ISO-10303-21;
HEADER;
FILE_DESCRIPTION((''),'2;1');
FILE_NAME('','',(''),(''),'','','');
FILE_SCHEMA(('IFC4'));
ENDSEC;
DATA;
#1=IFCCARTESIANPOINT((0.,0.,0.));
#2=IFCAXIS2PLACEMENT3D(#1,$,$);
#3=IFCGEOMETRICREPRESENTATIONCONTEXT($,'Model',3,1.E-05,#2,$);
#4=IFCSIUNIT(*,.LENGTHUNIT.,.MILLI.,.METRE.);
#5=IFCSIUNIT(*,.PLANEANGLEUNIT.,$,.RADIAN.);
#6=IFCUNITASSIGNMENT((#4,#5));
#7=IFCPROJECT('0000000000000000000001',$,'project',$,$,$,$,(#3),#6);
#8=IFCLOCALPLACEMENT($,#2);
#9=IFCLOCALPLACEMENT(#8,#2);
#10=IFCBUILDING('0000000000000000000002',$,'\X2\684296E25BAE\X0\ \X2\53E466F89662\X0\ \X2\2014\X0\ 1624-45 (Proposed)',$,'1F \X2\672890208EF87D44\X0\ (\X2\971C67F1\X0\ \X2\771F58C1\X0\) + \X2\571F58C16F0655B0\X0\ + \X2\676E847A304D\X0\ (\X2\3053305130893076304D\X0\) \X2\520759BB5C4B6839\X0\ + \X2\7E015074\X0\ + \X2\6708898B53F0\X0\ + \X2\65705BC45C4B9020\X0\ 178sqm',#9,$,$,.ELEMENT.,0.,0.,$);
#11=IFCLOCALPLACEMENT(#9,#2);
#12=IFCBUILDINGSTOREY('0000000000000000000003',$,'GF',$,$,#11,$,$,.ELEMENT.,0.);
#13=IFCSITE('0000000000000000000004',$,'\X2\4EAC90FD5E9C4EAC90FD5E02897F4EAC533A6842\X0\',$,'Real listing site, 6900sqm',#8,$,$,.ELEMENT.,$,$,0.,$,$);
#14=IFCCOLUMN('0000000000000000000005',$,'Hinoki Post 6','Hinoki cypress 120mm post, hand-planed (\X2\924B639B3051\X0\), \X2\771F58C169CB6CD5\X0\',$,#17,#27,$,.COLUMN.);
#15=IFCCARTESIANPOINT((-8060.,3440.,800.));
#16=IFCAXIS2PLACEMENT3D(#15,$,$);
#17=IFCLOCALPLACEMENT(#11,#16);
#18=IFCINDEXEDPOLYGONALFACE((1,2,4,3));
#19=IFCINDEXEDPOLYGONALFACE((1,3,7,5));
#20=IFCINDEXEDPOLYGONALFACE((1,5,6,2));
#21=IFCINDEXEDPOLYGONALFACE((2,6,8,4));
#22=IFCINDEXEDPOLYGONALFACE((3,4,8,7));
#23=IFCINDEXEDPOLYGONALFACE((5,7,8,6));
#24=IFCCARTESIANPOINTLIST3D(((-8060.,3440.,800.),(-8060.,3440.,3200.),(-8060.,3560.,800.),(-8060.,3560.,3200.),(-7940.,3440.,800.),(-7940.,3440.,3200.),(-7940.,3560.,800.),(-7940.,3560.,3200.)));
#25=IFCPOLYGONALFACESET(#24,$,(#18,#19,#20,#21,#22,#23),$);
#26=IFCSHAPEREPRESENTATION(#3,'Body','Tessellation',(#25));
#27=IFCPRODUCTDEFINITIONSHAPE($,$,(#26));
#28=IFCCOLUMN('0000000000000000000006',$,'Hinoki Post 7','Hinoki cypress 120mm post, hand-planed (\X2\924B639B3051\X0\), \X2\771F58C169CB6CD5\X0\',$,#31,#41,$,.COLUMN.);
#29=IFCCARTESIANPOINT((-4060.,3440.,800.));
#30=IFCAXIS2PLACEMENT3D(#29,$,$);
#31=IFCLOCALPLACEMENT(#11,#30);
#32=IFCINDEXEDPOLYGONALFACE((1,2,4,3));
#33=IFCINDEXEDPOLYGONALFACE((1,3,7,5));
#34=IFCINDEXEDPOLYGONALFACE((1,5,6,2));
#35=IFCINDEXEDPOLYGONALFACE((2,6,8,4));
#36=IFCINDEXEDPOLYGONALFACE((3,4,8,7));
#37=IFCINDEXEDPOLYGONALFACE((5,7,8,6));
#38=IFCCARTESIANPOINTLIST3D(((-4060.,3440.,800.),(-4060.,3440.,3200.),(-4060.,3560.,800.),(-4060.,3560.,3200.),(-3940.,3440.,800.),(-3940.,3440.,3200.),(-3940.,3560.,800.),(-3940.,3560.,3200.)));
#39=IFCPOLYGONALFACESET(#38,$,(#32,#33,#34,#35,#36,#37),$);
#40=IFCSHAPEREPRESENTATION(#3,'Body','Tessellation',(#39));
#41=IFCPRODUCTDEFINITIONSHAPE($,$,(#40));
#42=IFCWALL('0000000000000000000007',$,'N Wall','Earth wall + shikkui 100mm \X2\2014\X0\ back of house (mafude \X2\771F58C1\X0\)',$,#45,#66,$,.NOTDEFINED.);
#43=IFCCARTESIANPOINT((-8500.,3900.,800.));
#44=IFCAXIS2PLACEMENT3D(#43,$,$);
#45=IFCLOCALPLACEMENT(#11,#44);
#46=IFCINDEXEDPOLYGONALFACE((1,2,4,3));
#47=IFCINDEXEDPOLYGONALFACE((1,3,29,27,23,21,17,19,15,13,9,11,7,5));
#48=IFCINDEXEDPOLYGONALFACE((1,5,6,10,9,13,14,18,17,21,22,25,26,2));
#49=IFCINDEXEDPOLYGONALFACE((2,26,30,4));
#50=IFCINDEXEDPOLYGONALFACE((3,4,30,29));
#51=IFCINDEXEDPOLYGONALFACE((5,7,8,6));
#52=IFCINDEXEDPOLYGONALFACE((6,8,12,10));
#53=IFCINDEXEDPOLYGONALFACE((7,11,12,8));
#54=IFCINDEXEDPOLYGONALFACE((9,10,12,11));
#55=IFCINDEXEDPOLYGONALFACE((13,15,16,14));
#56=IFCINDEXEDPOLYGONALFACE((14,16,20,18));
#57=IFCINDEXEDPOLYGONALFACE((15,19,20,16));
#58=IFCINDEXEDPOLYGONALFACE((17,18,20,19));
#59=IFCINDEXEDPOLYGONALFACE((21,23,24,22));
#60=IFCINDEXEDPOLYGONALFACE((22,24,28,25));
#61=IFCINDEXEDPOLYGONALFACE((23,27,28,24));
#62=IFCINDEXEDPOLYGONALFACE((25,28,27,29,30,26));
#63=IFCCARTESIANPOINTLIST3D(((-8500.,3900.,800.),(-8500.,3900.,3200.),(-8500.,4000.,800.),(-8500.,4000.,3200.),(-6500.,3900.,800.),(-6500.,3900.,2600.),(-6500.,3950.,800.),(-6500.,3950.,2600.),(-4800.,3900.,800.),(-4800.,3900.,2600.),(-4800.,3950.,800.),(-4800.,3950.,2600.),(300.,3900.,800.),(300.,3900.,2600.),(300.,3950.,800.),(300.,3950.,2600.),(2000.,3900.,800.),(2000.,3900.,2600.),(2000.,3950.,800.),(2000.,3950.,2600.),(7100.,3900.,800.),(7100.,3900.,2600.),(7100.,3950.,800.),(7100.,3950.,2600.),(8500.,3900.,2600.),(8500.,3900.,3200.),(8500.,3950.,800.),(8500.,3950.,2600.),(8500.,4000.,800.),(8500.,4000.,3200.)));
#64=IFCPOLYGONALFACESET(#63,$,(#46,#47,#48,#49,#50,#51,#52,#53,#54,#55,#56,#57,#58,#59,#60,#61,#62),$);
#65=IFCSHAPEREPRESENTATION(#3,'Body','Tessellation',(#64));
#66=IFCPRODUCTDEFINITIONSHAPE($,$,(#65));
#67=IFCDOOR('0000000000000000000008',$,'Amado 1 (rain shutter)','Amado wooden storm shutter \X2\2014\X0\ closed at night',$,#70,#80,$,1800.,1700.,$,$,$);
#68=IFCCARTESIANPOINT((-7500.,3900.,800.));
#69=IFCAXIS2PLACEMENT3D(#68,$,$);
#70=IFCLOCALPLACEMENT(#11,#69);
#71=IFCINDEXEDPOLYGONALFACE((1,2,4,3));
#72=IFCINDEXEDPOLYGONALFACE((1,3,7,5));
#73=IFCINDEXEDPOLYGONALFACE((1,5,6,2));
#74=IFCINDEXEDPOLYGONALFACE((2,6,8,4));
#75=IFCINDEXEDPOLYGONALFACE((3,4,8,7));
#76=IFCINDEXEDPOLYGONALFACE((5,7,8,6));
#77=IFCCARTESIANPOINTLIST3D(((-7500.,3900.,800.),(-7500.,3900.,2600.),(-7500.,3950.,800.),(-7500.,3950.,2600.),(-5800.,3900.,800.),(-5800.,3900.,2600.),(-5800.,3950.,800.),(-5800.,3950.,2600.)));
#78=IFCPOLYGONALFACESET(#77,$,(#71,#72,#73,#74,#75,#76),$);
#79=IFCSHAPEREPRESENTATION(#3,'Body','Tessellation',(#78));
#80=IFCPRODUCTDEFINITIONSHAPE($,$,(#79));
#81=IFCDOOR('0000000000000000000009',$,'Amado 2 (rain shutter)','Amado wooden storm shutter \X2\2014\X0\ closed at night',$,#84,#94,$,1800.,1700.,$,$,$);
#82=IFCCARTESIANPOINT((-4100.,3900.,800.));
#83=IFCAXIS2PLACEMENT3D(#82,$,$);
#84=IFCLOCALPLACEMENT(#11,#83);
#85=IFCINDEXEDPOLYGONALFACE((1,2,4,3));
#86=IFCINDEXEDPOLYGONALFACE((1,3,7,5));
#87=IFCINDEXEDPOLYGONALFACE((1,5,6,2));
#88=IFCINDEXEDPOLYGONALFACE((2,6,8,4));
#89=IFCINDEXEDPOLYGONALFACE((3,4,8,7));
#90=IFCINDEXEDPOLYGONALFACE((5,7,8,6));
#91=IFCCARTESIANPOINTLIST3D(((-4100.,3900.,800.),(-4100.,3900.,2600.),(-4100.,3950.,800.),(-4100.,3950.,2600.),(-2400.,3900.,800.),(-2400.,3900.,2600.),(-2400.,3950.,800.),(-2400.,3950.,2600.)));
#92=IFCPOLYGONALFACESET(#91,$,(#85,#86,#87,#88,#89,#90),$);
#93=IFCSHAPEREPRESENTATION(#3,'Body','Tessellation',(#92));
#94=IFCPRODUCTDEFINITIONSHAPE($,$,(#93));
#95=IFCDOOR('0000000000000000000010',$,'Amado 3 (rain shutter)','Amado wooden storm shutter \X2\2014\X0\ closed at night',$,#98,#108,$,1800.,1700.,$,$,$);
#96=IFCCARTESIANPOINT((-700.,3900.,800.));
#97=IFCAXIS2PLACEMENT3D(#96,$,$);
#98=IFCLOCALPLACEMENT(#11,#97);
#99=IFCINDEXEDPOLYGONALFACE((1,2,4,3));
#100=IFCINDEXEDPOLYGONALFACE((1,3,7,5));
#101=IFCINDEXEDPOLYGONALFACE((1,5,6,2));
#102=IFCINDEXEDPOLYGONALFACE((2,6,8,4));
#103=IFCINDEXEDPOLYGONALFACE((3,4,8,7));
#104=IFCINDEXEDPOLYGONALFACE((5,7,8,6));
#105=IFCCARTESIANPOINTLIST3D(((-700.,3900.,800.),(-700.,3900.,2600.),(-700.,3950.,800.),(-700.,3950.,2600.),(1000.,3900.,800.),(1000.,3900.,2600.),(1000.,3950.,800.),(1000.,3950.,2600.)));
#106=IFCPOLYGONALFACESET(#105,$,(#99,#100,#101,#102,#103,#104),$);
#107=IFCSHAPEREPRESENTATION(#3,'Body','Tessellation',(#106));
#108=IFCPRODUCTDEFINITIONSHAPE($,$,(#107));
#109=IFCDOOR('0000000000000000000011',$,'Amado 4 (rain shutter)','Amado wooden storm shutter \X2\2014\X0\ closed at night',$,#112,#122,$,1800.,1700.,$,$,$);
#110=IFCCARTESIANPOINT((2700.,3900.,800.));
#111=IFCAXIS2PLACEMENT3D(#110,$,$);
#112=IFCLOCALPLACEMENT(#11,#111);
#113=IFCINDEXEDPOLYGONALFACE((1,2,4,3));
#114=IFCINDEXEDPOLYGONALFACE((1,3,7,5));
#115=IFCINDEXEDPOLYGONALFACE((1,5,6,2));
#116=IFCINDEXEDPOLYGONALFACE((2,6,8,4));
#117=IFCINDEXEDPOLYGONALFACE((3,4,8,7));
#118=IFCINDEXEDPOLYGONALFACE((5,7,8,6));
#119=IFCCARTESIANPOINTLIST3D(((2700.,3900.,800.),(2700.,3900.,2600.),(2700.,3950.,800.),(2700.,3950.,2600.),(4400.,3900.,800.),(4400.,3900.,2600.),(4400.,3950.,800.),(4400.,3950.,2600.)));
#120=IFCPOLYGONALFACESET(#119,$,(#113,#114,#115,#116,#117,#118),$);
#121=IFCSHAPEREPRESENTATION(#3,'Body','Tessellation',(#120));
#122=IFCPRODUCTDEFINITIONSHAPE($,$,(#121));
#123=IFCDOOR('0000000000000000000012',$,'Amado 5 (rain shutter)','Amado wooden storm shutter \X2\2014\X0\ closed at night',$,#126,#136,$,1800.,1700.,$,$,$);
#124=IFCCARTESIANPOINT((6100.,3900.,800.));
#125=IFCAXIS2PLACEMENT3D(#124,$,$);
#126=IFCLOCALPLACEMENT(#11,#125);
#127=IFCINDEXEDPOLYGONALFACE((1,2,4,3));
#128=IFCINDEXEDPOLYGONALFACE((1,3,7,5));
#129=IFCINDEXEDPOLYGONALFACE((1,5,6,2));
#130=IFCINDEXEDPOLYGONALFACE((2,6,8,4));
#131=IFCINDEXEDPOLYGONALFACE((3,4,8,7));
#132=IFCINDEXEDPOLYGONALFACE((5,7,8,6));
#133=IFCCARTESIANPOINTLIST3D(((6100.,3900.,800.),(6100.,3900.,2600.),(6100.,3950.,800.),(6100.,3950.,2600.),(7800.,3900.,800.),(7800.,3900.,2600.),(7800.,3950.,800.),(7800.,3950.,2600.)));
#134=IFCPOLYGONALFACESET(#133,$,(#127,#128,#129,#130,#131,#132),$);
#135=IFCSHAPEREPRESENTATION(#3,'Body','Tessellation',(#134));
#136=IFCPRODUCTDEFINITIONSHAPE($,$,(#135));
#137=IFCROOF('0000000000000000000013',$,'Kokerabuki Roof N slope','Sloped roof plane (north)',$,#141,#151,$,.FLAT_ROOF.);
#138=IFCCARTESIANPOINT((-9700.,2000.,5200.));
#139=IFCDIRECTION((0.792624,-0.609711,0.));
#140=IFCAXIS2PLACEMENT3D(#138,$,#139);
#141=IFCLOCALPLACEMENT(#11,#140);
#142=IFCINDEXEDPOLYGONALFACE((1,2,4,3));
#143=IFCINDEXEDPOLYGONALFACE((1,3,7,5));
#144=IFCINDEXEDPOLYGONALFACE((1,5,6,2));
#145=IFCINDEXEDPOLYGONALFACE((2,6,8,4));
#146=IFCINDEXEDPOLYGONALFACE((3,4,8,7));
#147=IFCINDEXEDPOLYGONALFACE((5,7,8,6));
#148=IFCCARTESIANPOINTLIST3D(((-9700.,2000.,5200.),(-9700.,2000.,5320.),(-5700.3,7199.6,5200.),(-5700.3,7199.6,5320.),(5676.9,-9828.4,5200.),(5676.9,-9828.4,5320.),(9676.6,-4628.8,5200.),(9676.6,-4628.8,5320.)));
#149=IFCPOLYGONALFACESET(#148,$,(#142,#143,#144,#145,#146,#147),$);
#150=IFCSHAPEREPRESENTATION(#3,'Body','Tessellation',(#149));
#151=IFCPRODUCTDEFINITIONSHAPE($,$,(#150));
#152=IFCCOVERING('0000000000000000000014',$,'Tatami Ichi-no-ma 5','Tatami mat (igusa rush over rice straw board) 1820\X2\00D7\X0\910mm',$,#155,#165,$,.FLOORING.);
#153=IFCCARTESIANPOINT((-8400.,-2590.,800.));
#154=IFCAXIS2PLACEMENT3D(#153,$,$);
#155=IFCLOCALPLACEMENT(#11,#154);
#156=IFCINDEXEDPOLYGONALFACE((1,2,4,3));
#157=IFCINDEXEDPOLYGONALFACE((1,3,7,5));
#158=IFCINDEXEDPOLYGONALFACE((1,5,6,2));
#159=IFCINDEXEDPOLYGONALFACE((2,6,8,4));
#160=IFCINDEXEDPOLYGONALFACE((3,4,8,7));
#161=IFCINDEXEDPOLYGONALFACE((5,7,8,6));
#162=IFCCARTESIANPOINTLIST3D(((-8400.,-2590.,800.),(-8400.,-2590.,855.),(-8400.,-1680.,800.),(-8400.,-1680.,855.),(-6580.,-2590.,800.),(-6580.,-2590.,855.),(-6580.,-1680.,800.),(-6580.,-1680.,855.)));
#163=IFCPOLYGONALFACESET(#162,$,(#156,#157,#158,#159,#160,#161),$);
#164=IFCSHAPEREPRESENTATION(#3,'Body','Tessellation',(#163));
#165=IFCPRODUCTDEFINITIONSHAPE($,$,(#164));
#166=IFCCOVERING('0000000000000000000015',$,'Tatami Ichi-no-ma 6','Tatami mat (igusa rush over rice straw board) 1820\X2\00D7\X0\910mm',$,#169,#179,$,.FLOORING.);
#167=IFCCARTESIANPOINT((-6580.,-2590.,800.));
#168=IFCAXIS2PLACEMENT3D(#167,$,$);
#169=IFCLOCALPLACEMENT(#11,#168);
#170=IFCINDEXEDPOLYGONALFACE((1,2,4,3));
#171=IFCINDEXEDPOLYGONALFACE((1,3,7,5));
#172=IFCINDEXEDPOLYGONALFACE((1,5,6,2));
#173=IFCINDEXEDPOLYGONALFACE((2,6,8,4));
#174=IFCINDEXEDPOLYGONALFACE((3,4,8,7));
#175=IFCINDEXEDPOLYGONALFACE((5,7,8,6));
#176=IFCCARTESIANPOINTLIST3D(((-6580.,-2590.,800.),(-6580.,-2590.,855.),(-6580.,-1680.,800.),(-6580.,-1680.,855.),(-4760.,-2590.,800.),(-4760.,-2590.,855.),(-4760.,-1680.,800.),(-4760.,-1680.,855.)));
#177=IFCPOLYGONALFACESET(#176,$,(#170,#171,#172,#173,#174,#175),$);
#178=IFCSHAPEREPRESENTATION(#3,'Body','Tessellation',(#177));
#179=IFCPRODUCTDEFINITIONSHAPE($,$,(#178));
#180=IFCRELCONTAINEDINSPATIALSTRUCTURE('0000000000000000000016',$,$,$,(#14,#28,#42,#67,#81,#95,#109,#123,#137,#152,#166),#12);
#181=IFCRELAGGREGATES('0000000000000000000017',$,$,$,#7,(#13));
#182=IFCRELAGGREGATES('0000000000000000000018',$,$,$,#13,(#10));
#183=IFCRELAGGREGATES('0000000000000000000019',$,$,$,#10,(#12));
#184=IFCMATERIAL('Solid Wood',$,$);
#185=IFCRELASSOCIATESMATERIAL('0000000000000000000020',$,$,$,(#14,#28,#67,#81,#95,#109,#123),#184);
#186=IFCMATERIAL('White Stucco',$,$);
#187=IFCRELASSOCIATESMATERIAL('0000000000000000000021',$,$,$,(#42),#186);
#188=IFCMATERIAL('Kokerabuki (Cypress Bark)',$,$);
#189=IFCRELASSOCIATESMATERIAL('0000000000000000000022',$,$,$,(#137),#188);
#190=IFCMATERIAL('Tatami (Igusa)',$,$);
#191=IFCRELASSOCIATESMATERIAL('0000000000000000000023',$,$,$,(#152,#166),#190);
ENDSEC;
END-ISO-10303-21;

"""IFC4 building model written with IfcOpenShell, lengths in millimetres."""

from ifc_helpers import new_model, si_unit, frame, frame_2d, origin, place, context, project, spatial, rectangle, extrude, material, element, fill, save


model = new_model("IFC4")

# Units and contexts
model_context = context("Model", 3, precision=1e-05, world=origin())
ifc_project = project(units=[si_unit("LENGTHUNIT", "METRE", prefix="MILLI"), si_unit("PLANEANGLEUNIT", "RADIAN")], contexts=[model_context])

# Site, building, storey
site_placement = place(None, origin())
site = spatial("IfcSite", under=ifc_project, at=site_placement, Name="京都府京都市西京区桂", ObjectType="Real listing site, 6900sqm", CompositionType="ELEMENT", RefElevation=0.0)
building_placement = place(site_placement, origin())
building = spatial("IfcBuilding", under=site, at=building_placement, Name="桂離宮 古書院 — 1624-45 (Proposed)", ObjectType="1F 木造軸組 (霜柱 真壁) + 土壁漆喰 + 杮葺き (こけらぶき) 切妻屋根 + 縁側 + 月見台 + 数寄屋造 178sqm", CompositionType="ELEMENT", ElevationOfRefHeight=0.0, ElevationOfTerrain=0.0)
storey_placement = place(building_placement, origin())
storey = spatial("IfcBuildingStorey", under=building, at=storey_placement, Name="GF", CompositionType="ELEMENT", Elevation=0.0)

# Columns
ifc_material_1 = material(Name="Solid Wood")
column_1_placement = place(storey_placement, frame((-8060.0, 3440.0, 800.0)))
element("IfcColumn", 1, at=column_1_placement, inside=storey, material=ifc_material_1, Name="Hinoki Post 6", Description="Hinoki cypress 120mm post, hand-planed (鉋掛け), 真壁構法", PredefinedType="COLUMN", context=model_context, shape_type="SweptSolid", body=[
    extrude(rectangle(XDim=120.0, YDim=120.0, at=frame_2d((60.0, 60.0))), frame((-8060.0, 3440.0, 800.0)), (0.0, 0.0, 1.0), 2400.0),
])
column_2_placement = place(storey_placement, frame((-4060.0, 3440.0, 800.0)))
element("IfcColumn", 2, at=column_2_placement, inside=storey, material=ifc_material_1, Name="Hinoki Post 7", Description="Hinoki cypress 120mm post, hand-planed (鉋掛け), 真壁構法", PredefinedType="COLUMN", context=model_context, shape_type="SweptSolid", body=[
    extrude(rectangle(XDim=120.0, YDim=120.0, at=frame_2d((60.0, 60.0))), frame((-4060.0, 3440.0, 800.0)), (0.0, 0.0, 1.0), 2400.0),
])

# Wall, openings, doors
ifc_material_2 = material(Name="White Stucco")
wall_placement = place(storey_placement, frame((-8500.0, 3900.0, 800.0)))
wall = element("IfcWall", 3, at=wall_placement, inside=storey, material=ifc_material_2, Name="N Wall", Description="Earth wall + shikkui 100mm — back of house (mafude 真壁)", PredefinedType="NOTDEFINED", context=model_context, shape_type="SweptSolid", body=[
    extrude(rectangle(XDim=17000.0, YDim=100.0, at=frame_2d((8500.0, 50.0))), frame((-8500.0, 3900.0, 800.0)), (0.0, 0.0, 1.0), 2400.0),
])
opening_1_placement = place(storey_placement, frame((-7500.0, 3900.0, 800.0)))
opening_1 = element("IfcOpeningElement", 4, at=opening_1_placement, cuts=wall, PredefinedType="NOTDEFINED", context=model_context, shape_type="SweptSolid", body=[
    extrude(rectangle(XDim=1700.0, YDim=50.0, at=frame_2d((850.0, 25.0))), frame((-7500.0, 3900.0, 800.0)), (0.0, 0.0, 1.0), 1800.0),
])
opening_2_placement = place(storey_placement, frame((-4100.0, 3900.0, 800.0)))
opening_2 = element("IfcOpeningElement", 5, at=opening_2_placement, cuts=wall, PredefinedType="NOTDEFINED", context=model_context, shape_type="SweptSolid", body=[
    extrude(rectangle(XDim=1700.0, YDim=50.0, at=frame_2d((850.0, 25.0))), frame((-4100.0, 3900.0, 800.0)), (0.0, 0.0, 1.0), 1800.0),
])
opening_3_placement = place(storey_placement, frame((-700.0, 3900.0, 800.0)))
opening_3 = element("IfcOpeningElement", 6, at=opening_3_placement, cuts=wall, PredefinedType="NOTDEFINED", context=model_context, shape_type="SweptSolid", body=[
    extrude(rectangle(XDim=1700.0, YDim=50.0, at=frame_2d((850.0, 25.0))), frame((-700.0, 3900.0, 800.0)), (0.0, 0.0, 1.0), 1800.0),
])
opening_4_placement = place(storey_placement, frame((2700.0, 3900.0, 800.0)))
opening_4 = element("IfcOpeningElement", 7, at=opening_4_placement, cuts=wall, PredefinedType="NOTDEFINED", context=model_context, shape_type="SweptSolid", body=[
    extrude(rectangle(XDim=1700.0, YDim=50.0, at=frame_2d((850.0, 25.0))), frame((2700.0, 3900.0, 800.0)), (0.0, 0.0, 1.0), 1800.0),
])
opening_5_placement = place(storey_placement, frame((6100.0, 3900.0, 800.0)))
opening_5 = element("IfcOpeningElement", 8, at=opening_5_placement, cuts=wall, PredefinedType="NOTDEFINED", context=model_context, shape_type="SweptSolid", body=[
    extrude(rectangle(XDim=1700.0, YDim=50.0, at=frame_2d((850.0, 25.0))), frame((6100.0, 3900.0, 800.0)), (0.0, 0.0, 1.0), 1800.0),
])
door_1_placement = place(storey_placement, frame((-7500.0, 3900.0, 800.0)))
door_1 = element("IfcDoor", 9, at=door_1_placement, inside=storey, material=ifc_material_1, Name="Amado 1 (rain shutter)", Description="Amado wooden storm shutter — closed at night", OverallHeight=1800.0, OverallWidth=1700.0, context=model_context, shape_type="SweptSolid", body=[
    extrude(rectangle(XDim=1700.0, YDim=50.0, at=frame_2d((850.0, 25.0))), frame((-7500.0, 3900.0, 800.0)), (0.0, 0.0, 1.0), 1800.0),
])
fill(opening_1, door_1)
door_2_placement = place(storey_placement, frame((-4100.0, 3900.0, 800.0)))
door_2 = element("IfcDoor", 10, at=door_2_placement, inside=storey, material=ifc_material_1, Name="Amado 2 (rain shutter)", Description="Amado wooden storm shutter — closed at night", OverallHeight=1800.0, OverallWidth=1700.0, context=model_context, shape_type="SweptSolid", body=[
    extrude(rectangle(XDim=1700.0, YDim=50.0, at=frame_2d((850.0, 25.0))), frame((-4100.0, 3900.0, 800.0)), (0.0, 0.0, 1.0), 1800.0),
])
fill(opening_2, door_2)
door_3_placement = place(storey_placement, frame((-700.0, 3900.0, 800.0)))
door_3 = element("IfcDoor", 11, at=door_3_placement, inside=storey, material=ifc_material_1, Name="Amado 3 (rain shutter)", Description="Amado wooden storm shutter — closed at night", OverallHeight=1800.0, OverallWidth=1700.0, context=model_context, shape_type="SweptSolid", body=[
    extrude(rectangle(XDim=1700.0, YDim=50.0, at=frame_2d((850.0, 25.0))), frame((-700.0, 3900.0, 800.0)), (0.0, 0.0, 1.0), 1800.0),
])
fill(opening_3, door_3)
door_4_placement = place(storey_placement, frame((2700.0, 3900.0, 800.0)))
door_4 = element("IfcDoor", 12, at=door_4_placement, inside=storey, material=ifc_material_1, Name="Amado 4 (rain shutter)", Description="Amado wooden storm shutter — closed at night", OverallHeight=1800.0, OverallWidth=1700.0, context=model_context, shape_type="SweptSolid", body=[
    extrude(rectangle(XDim=1700.0, YDim=50.0, at=frame_2d((850.0, 25.0))), frame((2700.0, 3900.0, 800.0)), (0.0, 0.0, 1.0), 1800.0),
])
fill(opening_4, door_4)
door_5_placement = place(storey_placement, frame((6100.0, 3900.0, 800.0)))
door_5 = element("IfcDoor", 13, at=door_5_placement, inside=storey, material=ifc_material_1, Name="Amado 5 (rain shutter)", Description="Amado wooden storm shutter — closed at night", OverallHeight=1800.0, OverallWidth=1700.0, context=model_context, shape_type="SweptSolid", body=[
    extrude(rectangle(XDim=1700.0, YDim=50.0, at=frame_2d((850.0, 25.0))), frame((6100.0, 3900.0, 800.0)), (0.0, 0.0, 1.0), 1800.0),
])
fill(opening_5, door_5)

# Roof
ifc_material_3 = material(Name="Kokerabuki (Cypress Bark)")
roof_1_placement = place(storey_placement, frame((-9700.0, 2000.0, 5200.0), x_axis=(0.792624, -0.609711, 0.0)))
element("IfcRoof", 14, at=roof_1_placement, inside=storey, material=ifc_material_3, Name="Kokerabuki Roof N slope", Description="Sloped roof plane (north)", PredefinedType="FLAT_ROOF", context=model_context, shape_type="SweptSolid", body=[
    extrude(rectangle(XDim=19400.0, YDim=6560.0, at=frame_2d((9700.0, 3280.0))), frame((-9700.0, 2000.0, 5200.0), x_axis=(0.792624, -0.609711, 0.0)), (0.0, 0.0, 1.0), 120.0),
])

# Coverings
ifc_material_4 = material(Name="Tatami (Igusa)")
covering_1_placement = place(storey_placement, frame((-8400.0, -2590.0, 800.0)))
element("IfcCovering", 15, at=covering_1_placement, inside=storey, material=ifc_material_4, Name="Tatami Ichi-no-ma 5", Description="Tatami mat (igusa rush over rice straw board) 1820×910mm", PredefinedType="FLOORING", context=model_context, shape_type="SweptSolid", body=[
    extrude(rectangle(XDim=1820.0, YDim=910.0, at=frame_2d((910.0, 455.0))), frame((-8400.0, -2590.0, 800.0)), (0.0, 0.0, 1.0), 55.0),
])
covering_2_placement = place(storey_placement, frame((-6580.0, -2590.0, 800.0)))
element("IfcCovering", 16, at=covering_2_placement, inside=storey, material=ifc_material_4, Name="Tatami Ichi-no-ma 6", Description="Tatami mat (igusa rush over rice straw board) 1820×910mm", PredefinedType="FLOORING", context=model_context, shape_type="SweptSolid", body=[
    extrude(rectangle(XDim=1820.0, YDim=910.0, at=frame_2d((910.0, 455.0))), frame((-6580.0, -2590.0, 800.0)), (0.0, 0.0, 1.0), 55.0),
])

save(model, "model.ifc")
